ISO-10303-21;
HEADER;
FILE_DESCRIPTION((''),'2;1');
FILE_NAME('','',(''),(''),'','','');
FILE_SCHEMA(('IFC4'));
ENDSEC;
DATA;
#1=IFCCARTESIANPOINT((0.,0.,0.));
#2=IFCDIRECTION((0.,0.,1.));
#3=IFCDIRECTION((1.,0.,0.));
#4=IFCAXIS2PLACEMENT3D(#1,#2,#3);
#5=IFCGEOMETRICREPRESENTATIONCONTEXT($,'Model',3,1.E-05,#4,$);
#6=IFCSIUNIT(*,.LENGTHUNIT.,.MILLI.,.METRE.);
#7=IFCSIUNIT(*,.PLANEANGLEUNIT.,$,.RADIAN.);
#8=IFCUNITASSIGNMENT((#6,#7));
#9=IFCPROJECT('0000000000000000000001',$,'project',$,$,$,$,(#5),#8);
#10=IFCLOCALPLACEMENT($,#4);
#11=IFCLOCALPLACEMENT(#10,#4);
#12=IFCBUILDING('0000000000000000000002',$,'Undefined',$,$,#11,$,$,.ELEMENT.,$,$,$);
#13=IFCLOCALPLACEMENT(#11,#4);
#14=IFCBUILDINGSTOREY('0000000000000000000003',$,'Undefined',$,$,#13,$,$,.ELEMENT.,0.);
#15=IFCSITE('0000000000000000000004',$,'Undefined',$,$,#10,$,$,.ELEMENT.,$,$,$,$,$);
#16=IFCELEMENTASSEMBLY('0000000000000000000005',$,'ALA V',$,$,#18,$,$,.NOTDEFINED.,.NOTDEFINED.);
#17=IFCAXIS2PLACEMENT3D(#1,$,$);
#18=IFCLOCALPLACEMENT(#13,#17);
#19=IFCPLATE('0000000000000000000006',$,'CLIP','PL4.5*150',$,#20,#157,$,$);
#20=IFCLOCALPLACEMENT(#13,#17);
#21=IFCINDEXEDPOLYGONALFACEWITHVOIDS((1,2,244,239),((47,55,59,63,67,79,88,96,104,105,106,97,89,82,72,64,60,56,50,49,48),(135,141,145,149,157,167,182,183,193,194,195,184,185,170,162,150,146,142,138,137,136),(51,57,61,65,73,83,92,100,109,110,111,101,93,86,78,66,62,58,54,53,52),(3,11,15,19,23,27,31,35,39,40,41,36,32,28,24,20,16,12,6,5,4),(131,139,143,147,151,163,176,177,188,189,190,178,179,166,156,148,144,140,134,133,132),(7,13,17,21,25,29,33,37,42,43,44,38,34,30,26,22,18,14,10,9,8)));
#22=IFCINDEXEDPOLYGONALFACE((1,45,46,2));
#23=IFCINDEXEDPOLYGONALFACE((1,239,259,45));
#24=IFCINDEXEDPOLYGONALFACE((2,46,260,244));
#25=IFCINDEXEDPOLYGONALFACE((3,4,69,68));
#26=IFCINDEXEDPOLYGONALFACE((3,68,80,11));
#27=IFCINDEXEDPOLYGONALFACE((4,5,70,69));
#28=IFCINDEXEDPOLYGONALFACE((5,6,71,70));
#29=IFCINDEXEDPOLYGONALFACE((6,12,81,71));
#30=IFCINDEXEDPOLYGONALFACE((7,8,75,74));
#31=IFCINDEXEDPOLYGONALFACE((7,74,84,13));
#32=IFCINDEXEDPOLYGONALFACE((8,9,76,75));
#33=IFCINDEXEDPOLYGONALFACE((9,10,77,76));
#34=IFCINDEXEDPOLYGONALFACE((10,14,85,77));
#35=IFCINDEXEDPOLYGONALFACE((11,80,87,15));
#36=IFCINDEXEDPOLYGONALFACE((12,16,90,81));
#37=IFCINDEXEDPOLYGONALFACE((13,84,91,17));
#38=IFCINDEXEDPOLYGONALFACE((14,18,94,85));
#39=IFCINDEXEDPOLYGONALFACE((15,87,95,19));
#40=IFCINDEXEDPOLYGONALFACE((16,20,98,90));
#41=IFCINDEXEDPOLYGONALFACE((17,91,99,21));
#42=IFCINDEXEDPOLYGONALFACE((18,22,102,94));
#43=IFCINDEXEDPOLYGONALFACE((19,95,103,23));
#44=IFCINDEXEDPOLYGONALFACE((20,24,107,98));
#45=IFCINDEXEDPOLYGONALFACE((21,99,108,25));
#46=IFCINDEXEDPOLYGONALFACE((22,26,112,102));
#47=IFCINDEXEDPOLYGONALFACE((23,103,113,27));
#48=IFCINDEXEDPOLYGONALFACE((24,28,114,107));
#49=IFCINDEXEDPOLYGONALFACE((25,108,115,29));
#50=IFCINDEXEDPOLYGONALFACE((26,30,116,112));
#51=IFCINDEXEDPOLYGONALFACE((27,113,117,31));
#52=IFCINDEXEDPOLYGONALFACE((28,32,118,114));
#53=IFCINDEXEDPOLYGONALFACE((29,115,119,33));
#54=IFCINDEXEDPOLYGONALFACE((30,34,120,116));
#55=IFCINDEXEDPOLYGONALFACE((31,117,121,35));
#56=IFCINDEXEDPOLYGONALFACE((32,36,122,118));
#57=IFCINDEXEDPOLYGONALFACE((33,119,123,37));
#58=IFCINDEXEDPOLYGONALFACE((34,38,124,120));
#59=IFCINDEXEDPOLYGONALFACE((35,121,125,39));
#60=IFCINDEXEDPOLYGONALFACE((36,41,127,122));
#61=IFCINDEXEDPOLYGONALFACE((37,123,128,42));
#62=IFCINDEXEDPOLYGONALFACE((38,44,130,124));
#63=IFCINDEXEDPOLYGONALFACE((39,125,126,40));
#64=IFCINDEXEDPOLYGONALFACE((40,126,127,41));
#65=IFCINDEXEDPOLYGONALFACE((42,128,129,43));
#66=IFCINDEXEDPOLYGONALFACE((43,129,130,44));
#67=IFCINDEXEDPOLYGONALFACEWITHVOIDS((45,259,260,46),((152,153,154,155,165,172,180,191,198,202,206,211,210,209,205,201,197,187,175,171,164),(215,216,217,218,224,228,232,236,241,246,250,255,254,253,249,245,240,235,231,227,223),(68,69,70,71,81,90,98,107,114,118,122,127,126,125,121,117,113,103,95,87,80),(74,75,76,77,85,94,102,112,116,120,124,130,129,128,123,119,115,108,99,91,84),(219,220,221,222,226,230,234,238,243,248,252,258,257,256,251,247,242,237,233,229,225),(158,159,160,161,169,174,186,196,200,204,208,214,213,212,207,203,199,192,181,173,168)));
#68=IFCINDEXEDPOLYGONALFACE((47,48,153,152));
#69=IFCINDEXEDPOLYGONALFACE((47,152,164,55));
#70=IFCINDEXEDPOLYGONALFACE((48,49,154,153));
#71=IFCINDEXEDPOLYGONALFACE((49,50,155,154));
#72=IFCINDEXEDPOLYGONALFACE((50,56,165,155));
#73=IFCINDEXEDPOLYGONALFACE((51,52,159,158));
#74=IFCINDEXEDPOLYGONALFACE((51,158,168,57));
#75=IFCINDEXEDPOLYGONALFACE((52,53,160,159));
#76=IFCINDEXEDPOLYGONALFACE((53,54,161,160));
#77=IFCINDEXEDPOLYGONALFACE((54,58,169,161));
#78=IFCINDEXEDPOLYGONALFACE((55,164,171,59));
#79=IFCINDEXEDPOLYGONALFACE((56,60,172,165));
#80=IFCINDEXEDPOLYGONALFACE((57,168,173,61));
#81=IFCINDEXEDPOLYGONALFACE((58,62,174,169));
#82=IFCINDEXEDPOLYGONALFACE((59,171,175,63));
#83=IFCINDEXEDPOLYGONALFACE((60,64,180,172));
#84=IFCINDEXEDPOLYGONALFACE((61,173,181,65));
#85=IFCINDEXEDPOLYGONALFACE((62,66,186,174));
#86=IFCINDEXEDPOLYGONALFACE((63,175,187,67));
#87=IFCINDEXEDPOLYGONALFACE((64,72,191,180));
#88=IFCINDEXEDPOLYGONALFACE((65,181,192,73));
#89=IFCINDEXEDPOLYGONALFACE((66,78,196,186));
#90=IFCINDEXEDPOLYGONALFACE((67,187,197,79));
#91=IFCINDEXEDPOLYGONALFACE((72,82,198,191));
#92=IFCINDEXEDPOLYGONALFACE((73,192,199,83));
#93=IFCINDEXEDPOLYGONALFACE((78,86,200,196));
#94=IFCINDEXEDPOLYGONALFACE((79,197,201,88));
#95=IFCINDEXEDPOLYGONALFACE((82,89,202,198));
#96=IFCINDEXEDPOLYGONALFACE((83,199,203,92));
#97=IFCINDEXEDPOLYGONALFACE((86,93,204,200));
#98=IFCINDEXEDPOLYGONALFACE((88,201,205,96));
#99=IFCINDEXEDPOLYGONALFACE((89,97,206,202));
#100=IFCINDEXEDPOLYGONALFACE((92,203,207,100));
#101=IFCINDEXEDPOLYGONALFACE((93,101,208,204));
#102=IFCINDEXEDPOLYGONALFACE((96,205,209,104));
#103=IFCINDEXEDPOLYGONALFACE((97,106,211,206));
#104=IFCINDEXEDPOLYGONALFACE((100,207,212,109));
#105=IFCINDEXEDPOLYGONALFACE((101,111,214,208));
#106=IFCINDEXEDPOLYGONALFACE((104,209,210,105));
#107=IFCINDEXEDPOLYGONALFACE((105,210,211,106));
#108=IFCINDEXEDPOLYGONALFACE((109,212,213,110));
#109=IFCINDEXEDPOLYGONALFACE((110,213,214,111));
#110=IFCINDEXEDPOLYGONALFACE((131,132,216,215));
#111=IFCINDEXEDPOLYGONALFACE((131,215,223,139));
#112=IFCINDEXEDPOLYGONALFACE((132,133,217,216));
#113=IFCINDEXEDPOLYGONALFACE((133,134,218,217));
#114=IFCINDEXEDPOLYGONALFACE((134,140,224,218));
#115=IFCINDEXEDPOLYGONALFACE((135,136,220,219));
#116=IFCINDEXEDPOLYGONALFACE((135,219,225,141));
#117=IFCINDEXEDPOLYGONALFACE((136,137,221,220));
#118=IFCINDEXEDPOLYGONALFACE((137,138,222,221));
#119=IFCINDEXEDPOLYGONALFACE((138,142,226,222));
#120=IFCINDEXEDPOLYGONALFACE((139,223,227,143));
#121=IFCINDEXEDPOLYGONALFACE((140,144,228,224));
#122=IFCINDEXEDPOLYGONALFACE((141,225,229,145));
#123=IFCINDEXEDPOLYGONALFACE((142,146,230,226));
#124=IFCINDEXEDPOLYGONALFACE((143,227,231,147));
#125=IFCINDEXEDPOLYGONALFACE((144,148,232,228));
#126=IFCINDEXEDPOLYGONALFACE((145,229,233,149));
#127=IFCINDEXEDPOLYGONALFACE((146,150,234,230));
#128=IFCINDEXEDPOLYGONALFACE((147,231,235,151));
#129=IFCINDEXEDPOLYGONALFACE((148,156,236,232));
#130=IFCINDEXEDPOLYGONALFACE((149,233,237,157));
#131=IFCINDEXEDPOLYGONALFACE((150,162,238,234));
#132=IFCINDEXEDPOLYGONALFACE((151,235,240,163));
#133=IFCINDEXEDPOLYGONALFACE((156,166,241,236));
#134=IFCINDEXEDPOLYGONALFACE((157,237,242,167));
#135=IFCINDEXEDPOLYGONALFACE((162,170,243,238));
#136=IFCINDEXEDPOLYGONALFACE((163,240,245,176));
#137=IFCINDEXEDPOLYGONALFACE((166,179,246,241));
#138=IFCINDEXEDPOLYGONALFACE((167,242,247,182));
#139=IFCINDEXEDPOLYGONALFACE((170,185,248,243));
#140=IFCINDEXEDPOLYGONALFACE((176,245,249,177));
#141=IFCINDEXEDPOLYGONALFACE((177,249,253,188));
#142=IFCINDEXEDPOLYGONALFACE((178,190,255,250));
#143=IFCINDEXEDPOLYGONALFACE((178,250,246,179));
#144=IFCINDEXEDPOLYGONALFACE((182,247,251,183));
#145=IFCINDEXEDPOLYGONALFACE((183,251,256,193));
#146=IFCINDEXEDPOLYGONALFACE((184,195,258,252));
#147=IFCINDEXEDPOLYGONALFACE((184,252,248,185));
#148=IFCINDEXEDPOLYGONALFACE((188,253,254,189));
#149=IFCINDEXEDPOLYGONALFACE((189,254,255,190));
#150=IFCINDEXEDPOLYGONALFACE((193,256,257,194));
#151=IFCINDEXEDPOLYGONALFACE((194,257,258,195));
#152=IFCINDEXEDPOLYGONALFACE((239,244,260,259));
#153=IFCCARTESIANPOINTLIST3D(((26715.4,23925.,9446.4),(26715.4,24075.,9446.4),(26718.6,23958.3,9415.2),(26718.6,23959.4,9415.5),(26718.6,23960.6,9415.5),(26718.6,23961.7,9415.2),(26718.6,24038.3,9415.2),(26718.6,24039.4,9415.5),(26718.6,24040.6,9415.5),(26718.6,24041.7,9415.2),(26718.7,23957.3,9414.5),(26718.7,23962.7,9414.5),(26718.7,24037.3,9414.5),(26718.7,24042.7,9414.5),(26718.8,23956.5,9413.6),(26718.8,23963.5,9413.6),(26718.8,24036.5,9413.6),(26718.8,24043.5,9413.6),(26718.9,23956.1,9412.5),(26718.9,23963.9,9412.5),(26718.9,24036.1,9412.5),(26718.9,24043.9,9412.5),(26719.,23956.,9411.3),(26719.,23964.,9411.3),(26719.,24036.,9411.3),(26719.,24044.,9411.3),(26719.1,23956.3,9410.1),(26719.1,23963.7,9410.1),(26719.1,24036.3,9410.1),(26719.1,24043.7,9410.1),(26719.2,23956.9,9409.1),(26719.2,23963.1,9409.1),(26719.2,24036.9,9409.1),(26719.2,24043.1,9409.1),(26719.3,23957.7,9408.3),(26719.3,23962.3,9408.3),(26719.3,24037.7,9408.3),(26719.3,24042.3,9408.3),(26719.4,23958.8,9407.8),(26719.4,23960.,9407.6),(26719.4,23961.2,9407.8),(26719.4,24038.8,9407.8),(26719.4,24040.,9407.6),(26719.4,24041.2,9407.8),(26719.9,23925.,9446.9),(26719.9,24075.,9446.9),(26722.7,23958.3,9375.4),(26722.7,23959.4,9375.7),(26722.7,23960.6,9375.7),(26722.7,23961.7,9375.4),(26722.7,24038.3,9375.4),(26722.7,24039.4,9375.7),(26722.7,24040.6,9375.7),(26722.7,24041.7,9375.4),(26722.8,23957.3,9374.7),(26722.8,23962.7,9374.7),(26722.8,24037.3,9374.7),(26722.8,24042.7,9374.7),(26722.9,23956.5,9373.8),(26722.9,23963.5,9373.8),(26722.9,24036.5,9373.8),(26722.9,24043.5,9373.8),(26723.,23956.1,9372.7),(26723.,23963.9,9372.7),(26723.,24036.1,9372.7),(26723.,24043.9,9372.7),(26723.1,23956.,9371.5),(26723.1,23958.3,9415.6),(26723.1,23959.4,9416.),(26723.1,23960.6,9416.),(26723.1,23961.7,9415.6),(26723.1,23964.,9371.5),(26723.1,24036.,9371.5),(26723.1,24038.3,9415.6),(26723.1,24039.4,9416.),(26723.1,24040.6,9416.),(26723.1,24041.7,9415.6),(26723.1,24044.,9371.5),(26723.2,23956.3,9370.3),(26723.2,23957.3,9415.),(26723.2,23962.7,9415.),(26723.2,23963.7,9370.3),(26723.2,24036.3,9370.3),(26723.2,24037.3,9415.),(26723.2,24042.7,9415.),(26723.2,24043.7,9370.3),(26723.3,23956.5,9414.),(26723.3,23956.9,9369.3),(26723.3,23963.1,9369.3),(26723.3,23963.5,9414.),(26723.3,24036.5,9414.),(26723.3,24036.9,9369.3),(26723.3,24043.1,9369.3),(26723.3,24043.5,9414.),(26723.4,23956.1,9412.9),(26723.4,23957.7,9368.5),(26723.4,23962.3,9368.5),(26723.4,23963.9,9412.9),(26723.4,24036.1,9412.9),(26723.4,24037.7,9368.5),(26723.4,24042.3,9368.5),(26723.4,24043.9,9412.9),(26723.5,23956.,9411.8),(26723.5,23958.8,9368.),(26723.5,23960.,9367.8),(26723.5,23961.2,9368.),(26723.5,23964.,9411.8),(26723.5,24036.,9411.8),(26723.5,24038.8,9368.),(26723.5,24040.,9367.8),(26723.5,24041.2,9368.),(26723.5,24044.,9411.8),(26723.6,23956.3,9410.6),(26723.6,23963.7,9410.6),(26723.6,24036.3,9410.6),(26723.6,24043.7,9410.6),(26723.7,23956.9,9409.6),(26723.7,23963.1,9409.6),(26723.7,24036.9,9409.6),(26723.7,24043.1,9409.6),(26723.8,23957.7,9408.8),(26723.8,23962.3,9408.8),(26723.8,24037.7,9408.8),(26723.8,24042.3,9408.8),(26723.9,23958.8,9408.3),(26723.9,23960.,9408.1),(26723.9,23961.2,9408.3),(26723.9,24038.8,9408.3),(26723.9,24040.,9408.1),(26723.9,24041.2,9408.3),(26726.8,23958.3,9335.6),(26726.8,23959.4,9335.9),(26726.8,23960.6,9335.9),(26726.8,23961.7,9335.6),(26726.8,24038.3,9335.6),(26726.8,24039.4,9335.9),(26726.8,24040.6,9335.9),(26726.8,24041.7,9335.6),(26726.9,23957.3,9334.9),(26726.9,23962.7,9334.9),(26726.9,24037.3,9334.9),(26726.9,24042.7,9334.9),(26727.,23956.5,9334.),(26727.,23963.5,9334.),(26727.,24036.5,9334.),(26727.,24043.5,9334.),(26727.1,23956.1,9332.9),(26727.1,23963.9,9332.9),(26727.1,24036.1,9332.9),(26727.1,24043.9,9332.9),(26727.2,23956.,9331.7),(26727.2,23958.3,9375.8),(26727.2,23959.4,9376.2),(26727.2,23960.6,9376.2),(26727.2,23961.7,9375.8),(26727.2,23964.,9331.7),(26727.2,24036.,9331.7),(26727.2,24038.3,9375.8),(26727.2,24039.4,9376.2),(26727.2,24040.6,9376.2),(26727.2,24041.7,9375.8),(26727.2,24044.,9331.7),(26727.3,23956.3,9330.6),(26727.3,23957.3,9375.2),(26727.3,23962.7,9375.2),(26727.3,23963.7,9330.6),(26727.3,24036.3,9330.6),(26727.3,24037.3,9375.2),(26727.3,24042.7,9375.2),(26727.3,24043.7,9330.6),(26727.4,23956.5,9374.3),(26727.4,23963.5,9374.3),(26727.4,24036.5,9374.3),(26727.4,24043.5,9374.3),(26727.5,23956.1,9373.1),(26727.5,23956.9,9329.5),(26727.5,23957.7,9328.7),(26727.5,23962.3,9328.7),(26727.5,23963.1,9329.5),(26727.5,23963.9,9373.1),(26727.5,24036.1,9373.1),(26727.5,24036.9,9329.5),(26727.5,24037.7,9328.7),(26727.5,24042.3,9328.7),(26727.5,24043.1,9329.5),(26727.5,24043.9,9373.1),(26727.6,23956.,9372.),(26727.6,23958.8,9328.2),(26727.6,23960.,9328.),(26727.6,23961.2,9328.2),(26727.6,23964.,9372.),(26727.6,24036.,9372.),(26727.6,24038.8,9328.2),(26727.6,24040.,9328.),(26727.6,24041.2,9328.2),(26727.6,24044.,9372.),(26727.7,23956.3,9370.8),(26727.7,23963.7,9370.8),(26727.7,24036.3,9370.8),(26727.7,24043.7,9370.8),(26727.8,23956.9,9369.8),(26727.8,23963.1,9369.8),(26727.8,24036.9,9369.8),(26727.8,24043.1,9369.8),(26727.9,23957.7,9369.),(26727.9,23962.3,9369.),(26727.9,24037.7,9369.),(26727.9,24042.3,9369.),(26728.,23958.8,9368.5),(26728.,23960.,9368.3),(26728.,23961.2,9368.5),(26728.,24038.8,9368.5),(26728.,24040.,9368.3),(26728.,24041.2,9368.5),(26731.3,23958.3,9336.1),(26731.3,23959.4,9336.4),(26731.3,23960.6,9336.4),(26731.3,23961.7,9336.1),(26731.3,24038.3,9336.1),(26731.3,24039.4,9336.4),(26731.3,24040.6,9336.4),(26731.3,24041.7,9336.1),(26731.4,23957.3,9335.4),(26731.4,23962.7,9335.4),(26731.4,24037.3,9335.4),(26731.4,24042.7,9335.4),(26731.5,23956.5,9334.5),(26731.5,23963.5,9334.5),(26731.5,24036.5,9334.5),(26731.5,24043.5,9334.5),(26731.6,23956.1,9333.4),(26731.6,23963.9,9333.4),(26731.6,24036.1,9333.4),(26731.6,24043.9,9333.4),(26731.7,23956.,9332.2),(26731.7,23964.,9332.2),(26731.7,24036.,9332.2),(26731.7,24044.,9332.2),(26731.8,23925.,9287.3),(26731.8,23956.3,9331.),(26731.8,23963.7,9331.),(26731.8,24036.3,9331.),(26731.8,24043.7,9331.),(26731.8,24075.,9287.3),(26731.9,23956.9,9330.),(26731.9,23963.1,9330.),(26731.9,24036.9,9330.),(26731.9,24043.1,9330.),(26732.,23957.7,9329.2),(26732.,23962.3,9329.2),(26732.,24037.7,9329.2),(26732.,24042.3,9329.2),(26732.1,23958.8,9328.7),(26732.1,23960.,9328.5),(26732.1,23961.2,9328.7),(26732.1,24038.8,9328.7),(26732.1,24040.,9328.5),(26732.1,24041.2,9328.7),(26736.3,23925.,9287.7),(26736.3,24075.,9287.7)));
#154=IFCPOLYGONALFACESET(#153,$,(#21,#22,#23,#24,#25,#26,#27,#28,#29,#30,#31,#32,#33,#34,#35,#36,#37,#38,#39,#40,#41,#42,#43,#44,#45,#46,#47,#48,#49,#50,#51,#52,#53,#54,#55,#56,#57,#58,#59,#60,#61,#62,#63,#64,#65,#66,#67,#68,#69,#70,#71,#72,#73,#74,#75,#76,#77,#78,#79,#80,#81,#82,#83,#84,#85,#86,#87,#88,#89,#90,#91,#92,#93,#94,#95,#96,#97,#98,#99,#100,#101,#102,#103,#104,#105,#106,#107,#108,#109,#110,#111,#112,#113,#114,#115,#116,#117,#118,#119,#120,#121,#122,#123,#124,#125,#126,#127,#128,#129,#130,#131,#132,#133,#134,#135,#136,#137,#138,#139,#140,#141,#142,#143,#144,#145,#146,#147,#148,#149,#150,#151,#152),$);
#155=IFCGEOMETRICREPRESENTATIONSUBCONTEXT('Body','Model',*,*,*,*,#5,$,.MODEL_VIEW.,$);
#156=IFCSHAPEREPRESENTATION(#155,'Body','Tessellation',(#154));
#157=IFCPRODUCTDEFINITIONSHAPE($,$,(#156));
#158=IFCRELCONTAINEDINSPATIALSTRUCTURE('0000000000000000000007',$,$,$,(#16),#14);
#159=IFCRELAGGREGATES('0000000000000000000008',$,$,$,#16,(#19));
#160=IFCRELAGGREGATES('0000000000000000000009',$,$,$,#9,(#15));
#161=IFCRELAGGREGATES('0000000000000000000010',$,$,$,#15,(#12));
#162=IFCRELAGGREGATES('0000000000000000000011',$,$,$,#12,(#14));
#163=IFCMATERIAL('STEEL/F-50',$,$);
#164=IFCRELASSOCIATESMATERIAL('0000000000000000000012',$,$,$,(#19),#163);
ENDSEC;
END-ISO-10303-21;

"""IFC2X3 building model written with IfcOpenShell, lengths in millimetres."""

from ifc_helpers import new_model, si_unit, frame, origin_with_axes, origin_2d_with_axis, place, context, subcontext, project, spatial, polyline, circle, outline, extrude, source, transform, mapped, material, element, aggregate, save


model = new_model("IFC2X3")

# Units and contexts
model_context = context("Model", 3, precision=1e-05, world=origin_with_axes())
body_context = subcontext(model_context, "Body", "Model", "MODEL_VIEW")
ifc_project = project(units=[si_unit("LENGTHUNIT", "METRE", prefix="MILLI"), si_unit("PLANEANGLEUNIT", "RADIAN")], contexts=[model_context])

# Site, building, storey
site_placement = place(None, origin_with_axes())
site = spatial("IfcSite", under=ifc_project, at=site_placement, Name="Undefined", CompositionType="ELEMENT")
building_placement = place(site_placement, origin_with_axes())
building = spatial("IfcBuilding", under=site, at=building_placement, Name="Undefined", CompositionType="ELEMENT")
storey_placement = place(building_placement, origin_with_axes())
storey = spatial("IfcBuildingStorey", under=building, at=storey_placement, Name="Undefined", CompositionType="ELEMENT", Elevation=0.0)

# Shared definitions
ifc_material_1 = material(Name="STEEL/F-50")

# Element assembly, plate, openings
assembly_1_placement = place(storey_placement, origin_with_axes())
assembly_1 = element("IfcElementAssembly", 1, at=assembly_1_placement, inside=storey, Name="ALA V", AssemblyPlace="NOTDEFINED", PredefinedType="NOTDEFINED")
shared_shape_1 = source(origin_with_axes(), body_context, "Body", "SweptSolid", [
    extrude(circle(Radius=4.0, at=origin_2d_with_axis()), frame((0.0, -4.6, 0.0), z_axis=(0.0, 1.0, 0.0), x_axis=(1.0, 0.0, 0.0)), (0.0, 0.0, 1.0), 4.7),
])
plate_1_placement = place(assembly_1_placement, frame((26717.6, 23925.0, 9446.6), z_axis=(0.994727, 0.0, 0.102562), x_axis=(0.102562, 0.0, -0.994727)))
plate_1 = element("IfcPlate", 2, at=plate_1_placement, material=ifc_material_1, Name="CLIP", Description="PL4.5*150", context=body_context, shape_type="SweptSolid", body=[
    extrude(outline(polyline([(0.0, 0.0), (160.0, 0.0), (160.0, 150.0), (0.0, 150.0), (0.0, 0.0)])), frame((0.0, 0.0, -2.2), z_axis=(0.0, 0.0, 1.0), x_axis=(1.0, 0.0, 0.0)), (0.0, 0.0, 1.0), 4.5),
])
opening_1_placement = place(assembly_1_placement, frame((26719.0, 24040.0, 9411.6), z_axis=(0.0, 1.0, 0.0), x_axis=(0.102562, 0.0, -0.994727)))
element("IfcOpeningElement", 3, at=opening_1_placement, cuts=plate_1, ObjectType="Opening", context=body_context, shape_type="MappedRepresentation", body=[
    mapped(shared_shape_1, transform((0.0, 0.0, 0.0))),
    mapped(shared_shape_1, transform((40.0, 0.0, 0.0))),
    mapped(shared_shape_1, transform((80.0, 0.0, 0.0))),
])
opening_2_placement = place(assembly_1_placement, frame((26719.0, 23960.0, 9411.6), z_axis=(0.0, 1.0, 0.0), x_axis=(0.102562, 0.0, -0.994727)))
element("IfcOpeningElement", 4, at=opening_2_placement, cuts=plate_1, ObjectType="Opening", context=body_context, shape_type="MappedRepresentation", body=[
    mapped(shared_shape_1, transform((0.0, 0.0, 0.0))),
    mapped(shared_shape_1, transform((40.0, 0.0, 0.0))),
    mapped(shared_shape_1, transform((80.0, 0.0, 0.0))),
])

aggregate(assembly_1, [plate_1])

save(model, "model.ifc")
